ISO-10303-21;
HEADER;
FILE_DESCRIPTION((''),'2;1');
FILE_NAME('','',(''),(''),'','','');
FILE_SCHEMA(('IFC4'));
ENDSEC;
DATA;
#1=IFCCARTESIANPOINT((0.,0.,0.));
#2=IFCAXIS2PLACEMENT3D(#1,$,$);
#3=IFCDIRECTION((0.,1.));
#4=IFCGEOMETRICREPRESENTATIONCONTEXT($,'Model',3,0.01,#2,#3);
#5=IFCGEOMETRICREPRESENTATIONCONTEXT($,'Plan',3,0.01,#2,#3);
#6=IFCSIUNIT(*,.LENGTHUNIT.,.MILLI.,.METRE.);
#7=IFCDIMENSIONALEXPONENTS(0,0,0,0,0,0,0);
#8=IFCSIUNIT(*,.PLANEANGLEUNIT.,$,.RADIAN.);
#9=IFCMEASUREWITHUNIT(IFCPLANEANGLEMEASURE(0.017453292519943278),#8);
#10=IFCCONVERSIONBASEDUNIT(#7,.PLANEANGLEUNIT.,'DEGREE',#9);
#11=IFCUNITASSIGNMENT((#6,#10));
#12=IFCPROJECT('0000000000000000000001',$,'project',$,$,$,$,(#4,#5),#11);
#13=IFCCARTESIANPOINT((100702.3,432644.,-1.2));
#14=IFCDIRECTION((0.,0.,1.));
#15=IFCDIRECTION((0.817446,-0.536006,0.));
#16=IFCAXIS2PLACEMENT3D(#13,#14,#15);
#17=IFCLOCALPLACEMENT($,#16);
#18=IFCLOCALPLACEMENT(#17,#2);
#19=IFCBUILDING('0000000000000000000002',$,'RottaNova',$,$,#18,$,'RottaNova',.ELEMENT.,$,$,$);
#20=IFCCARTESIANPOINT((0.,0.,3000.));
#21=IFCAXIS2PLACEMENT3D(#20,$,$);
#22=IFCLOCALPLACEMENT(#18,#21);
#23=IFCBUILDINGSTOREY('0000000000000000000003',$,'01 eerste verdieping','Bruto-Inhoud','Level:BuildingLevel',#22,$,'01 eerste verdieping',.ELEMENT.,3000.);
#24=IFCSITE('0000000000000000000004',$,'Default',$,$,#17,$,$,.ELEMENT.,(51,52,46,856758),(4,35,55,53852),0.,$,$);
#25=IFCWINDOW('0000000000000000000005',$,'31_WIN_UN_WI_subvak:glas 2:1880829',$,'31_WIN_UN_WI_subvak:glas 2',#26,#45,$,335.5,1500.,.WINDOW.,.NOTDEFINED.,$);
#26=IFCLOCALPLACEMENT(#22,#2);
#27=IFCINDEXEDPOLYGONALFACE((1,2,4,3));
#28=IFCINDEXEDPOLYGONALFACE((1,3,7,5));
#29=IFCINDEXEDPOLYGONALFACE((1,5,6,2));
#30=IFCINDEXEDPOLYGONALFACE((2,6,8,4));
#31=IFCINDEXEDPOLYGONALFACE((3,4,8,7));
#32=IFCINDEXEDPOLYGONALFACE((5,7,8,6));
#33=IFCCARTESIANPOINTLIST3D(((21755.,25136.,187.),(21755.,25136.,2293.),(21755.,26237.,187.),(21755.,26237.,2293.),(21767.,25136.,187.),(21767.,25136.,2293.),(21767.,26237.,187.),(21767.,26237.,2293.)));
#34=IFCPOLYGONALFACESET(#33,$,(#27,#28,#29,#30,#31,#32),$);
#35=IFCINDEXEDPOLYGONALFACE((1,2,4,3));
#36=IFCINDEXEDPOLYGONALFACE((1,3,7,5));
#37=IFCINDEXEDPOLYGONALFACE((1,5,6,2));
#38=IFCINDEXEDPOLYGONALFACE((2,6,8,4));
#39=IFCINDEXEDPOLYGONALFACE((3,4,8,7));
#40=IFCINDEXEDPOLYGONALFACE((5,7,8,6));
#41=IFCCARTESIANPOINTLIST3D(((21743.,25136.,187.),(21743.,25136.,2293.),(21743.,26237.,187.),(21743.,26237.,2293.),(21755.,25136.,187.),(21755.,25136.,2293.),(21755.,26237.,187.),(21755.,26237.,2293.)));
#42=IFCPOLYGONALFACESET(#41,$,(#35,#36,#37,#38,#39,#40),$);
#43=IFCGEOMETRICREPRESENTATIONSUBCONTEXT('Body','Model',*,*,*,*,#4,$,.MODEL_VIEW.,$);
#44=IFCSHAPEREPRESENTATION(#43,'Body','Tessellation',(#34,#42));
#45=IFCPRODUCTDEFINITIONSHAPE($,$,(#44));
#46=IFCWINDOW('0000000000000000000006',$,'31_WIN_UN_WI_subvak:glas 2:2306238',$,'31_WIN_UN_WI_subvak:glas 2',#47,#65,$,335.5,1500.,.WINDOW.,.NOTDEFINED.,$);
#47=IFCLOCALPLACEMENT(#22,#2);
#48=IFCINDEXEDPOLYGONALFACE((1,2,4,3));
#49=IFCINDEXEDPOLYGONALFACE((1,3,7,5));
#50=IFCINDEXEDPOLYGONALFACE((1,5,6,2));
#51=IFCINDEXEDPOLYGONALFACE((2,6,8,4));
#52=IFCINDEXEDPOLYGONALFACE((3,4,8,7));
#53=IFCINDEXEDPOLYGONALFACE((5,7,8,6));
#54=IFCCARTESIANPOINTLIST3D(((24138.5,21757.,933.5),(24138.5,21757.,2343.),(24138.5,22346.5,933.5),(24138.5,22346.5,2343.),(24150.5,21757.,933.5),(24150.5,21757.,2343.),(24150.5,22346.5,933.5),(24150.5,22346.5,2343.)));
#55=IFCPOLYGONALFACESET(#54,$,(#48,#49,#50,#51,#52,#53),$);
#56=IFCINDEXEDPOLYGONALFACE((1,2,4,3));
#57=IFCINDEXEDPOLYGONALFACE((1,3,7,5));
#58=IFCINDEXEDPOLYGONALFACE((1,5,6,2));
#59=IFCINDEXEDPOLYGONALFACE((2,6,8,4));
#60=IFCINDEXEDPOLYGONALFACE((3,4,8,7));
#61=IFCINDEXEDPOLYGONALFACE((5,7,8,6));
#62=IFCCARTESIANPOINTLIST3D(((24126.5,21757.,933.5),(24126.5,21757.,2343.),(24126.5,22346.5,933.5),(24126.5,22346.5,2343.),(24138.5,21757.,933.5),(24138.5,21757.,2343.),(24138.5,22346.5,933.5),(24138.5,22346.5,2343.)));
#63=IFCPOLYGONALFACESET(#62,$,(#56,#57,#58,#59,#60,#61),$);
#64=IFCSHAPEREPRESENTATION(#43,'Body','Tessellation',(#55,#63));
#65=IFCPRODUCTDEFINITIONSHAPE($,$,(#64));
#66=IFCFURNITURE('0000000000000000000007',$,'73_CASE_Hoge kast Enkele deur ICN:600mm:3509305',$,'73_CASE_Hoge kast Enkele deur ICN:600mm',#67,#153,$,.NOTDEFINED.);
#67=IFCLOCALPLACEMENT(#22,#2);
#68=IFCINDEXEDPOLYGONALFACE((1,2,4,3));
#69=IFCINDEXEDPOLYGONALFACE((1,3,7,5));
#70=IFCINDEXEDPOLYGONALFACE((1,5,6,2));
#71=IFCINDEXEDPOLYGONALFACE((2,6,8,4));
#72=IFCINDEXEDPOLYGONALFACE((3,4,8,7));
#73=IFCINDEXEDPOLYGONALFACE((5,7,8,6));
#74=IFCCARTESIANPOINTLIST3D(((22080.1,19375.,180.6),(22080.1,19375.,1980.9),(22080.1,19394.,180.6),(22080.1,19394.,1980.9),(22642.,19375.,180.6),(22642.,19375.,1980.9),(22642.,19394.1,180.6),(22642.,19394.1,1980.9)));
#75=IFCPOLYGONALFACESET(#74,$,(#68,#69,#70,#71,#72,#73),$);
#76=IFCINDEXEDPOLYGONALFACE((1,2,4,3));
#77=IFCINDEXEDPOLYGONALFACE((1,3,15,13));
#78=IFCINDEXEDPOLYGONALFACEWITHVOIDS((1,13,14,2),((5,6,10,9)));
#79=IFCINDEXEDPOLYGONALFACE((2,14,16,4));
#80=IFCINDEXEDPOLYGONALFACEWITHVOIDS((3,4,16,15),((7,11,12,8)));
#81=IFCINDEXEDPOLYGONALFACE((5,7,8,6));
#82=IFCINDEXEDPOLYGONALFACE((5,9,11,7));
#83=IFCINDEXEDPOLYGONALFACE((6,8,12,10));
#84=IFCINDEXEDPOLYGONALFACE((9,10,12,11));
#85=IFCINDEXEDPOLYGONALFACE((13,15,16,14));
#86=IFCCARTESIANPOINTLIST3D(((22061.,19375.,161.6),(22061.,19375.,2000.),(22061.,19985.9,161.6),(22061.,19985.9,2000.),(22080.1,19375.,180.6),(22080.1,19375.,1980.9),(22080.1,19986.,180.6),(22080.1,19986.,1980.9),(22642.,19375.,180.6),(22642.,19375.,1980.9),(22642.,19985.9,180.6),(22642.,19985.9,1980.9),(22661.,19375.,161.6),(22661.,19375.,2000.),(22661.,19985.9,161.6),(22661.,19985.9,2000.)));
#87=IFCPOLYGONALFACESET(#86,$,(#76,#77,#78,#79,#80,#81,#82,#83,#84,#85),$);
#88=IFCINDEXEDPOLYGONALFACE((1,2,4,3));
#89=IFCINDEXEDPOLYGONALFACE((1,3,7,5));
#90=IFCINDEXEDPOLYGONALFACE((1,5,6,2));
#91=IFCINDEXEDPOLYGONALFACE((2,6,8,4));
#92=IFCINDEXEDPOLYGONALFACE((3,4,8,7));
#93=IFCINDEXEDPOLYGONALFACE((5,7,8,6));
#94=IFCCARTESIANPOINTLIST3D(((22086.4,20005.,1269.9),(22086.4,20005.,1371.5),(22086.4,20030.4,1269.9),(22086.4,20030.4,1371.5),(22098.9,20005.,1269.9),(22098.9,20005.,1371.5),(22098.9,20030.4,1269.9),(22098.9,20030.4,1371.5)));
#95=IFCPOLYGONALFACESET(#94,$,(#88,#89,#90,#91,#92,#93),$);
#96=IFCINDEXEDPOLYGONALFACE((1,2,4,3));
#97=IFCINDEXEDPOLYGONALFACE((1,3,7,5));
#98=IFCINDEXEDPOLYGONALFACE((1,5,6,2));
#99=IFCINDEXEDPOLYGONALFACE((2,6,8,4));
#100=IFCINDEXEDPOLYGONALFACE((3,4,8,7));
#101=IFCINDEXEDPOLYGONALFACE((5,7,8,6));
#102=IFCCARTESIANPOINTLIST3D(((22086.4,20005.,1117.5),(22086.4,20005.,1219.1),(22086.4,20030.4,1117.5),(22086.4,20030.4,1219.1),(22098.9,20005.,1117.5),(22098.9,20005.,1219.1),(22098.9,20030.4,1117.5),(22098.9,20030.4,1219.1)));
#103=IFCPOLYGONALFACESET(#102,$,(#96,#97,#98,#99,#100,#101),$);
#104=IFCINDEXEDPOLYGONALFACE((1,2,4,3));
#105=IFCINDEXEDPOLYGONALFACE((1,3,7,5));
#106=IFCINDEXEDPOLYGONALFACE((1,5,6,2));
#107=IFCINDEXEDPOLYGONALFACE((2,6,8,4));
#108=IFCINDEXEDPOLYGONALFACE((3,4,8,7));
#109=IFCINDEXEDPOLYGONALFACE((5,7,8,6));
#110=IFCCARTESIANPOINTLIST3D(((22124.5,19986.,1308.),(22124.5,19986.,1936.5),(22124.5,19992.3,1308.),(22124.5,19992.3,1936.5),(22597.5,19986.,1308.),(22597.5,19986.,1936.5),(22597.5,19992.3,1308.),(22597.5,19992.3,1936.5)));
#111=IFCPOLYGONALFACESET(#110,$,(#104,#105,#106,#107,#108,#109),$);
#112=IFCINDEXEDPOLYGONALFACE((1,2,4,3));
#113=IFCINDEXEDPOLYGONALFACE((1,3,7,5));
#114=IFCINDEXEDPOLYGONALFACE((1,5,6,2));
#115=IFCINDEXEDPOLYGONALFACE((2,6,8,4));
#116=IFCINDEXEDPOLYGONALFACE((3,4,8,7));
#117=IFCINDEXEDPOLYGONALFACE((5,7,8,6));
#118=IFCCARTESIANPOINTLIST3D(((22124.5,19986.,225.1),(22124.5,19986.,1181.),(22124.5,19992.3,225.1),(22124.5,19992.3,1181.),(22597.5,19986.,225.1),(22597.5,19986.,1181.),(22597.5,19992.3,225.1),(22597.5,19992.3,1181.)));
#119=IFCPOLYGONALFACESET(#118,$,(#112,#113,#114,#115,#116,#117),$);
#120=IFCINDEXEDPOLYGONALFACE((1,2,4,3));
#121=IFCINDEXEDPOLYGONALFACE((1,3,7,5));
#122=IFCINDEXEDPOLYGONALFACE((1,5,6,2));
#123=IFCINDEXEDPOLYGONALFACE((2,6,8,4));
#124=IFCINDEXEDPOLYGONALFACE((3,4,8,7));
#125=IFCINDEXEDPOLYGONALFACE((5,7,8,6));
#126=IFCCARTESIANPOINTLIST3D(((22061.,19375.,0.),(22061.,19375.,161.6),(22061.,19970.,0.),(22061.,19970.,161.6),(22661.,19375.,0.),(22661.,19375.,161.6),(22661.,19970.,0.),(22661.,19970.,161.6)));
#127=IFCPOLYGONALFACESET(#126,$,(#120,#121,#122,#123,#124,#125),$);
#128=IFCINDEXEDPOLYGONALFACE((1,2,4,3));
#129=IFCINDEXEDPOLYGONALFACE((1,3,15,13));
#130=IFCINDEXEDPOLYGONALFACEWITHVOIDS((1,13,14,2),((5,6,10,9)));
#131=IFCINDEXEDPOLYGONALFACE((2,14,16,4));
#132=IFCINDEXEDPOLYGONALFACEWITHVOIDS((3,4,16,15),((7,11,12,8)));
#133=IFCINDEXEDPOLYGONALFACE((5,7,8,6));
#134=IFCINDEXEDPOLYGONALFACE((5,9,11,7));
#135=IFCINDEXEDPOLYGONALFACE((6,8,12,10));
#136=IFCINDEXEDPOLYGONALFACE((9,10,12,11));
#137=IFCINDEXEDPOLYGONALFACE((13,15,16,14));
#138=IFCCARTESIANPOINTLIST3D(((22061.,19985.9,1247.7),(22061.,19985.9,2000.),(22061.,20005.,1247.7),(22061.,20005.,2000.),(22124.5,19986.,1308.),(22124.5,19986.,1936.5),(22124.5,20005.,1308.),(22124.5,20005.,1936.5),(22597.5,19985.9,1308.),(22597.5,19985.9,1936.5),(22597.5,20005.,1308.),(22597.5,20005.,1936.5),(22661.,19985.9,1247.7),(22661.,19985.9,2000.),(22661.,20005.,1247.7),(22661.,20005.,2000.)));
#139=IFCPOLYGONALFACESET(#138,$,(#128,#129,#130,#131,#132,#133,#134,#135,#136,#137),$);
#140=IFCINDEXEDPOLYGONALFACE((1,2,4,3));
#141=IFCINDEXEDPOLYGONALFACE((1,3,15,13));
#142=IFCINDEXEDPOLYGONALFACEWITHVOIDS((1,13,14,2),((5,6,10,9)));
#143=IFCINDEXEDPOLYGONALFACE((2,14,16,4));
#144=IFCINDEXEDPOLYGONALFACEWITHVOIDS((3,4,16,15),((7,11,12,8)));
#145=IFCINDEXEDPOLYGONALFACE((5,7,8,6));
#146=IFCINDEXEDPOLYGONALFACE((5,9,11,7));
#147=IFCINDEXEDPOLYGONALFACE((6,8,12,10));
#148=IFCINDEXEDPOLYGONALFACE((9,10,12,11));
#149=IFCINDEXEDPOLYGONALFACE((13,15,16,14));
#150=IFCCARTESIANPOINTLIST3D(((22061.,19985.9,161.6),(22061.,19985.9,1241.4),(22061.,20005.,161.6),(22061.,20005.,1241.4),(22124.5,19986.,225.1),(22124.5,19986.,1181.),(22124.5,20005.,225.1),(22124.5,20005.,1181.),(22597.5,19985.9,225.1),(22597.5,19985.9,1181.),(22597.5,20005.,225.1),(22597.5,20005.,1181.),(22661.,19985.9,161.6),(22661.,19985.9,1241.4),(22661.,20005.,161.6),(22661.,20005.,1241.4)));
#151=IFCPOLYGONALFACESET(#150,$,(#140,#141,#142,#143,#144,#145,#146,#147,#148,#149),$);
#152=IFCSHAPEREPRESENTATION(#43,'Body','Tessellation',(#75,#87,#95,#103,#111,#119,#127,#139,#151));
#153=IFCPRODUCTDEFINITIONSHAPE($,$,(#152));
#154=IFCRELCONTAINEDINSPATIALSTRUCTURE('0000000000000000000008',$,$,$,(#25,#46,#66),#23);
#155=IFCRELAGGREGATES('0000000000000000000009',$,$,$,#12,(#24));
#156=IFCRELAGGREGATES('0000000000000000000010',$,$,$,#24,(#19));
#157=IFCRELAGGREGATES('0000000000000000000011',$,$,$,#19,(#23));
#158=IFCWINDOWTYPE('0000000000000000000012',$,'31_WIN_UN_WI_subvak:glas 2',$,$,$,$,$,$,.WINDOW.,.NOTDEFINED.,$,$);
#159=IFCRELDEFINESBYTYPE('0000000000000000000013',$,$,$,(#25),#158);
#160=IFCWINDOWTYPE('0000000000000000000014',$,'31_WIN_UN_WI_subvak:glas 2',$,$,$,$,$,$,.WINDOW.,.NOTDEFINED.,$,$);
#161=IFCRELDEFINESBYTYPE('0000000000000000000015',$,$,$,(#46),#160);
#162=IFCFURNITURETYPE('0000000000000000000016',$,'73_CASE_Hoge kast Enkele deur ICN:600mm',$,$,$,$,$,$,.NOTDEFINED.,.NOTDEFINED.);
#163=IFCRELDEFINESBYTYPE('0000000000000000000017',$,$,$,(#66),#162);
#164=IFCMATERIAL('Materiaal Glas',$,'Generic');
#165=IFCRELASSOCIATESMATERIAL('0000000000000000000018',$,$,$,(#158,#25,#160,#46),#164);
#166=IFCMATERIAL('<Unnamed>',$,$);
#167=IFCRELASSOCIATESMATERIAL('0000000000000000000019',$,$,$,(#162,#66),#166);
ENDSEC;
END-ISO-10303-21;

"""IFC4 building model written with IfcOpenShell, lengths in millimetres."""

from ifc_helpers import new_model, entity, si_unit, converted_unit, direction, frame, origin, place, context, subcontext, project, spatial, indexed_curve, outline, extrude, source, transform, mapped, material, type_object, type_shapes, element, save


model = new_model("IFC4")

# Units and contexts
model_context = context("Model", 3, precision=0.01, world=origin(), true_north=direction((0.0, 1.0)))
plan_context = context("Plan", 3, precision=0.01, world=origin(), true_north=direction((0.0, 1.0)))
body_context = subcontext(model_context, "Body", "Model", "MODEL_VIEW")
ifc_project = project(units=[si_unit("LENGTHUNIT", "METRE", prefix="MILLI"), converted_unit("PLANEANGLEUNIT", "DEGREE", entity("IfcPlaneAngleMeasure", 0.017453292519943278), si_unit("PLANEANGLEUNIT", "RADIAN"), dimensions=[0, 0, 0, 0, 0, 0, 0])], contexts=[model_context, plan_context])

# Site, building, storey
site_placement = place(None, frame((100702.3, 432644.0, -1.2), z_axis=(0.0, 0.0, 1.0), x_axis=(0.817446, -0.536006, 0.0)))
site = spatial("IfcSite", under=ifc_project, at=site_placement, Name="Default", CompositionType="ELEMENT", RefLatitude=(51, 52, 46, 856758), RefLongitude=(4, 35, 55, 53852), RefElevation=0.0)
building_placement = place(site_placement, origin())
building = spatial("IfcBuilding", under=site, at=building_placement, Name="RottaNova", LongName="RottaNova", CompositionType="ELEMENT")
storey_placement = place(building_placement, frame((0.0, 0.0, 3000.0)))
storey = spatial("IfcBuildingStorey", under=building, at=storey_placement, Name="01 eerste verdieping", Description="Bruto-Inhoud", ObjectType="Level:BuildingLevel", LongName="01 eerste verdieping", CompositionType="ELEMENT", Elevation=3000.0)

# Shared definitions
ifc_material_1 = material(Name="Materiaal Glas", Category="Generic")

# Windows
window_type_1 = type_object("IfcWindowType", Name="31_WIN_UN_WI_subvak:glas 2", PartitioningType="NOTDEFINED", PredefinedType="WINDOW", material=ifc_material_1)
shared_shape_1 = source(origin(), body_context, "Body", "SweptSolid", [
    extrude(outline(indexed_curve([(-6.0, -550.5), (6.0, -550.5), (6.0, 550.5), (-6.0, 550.5), (-6.0, -550.5)], self_intersect=False)), frame((0.0, 6.0, 0.0), z_axis=(0.0, 0.0, 1.0), x_axis=(0.0, -1.0, 0.0)), (0.0, 0.0, 1.0), 2106.0),
    extrude(outline(indexed_curve([(-6.0, -550.5), (6.0, -550.5), (6.0, 550.5), (-6.0, 550.5), (-6.0, -550.5)], self_intersect=False)), frame((0.0, -6.0, 0.0), z_axis=(0.0, 0.0, 1.0), x_axis=(0.0, -1.0, 0.0)), (0.0, 0.0, 1.0), 2106.0),
])
type_shapes(window_type_1, [shared_shape_1])
window_1_placement = place(storey_placement, frame((21755.0, 25686.5, 187.0), z_axis=(0.0, 0.0, 1.0), x_axis=(0.0, -1.0, 0.0)))
element("IfcWindow", 1, at=window_1_placement, inside=storey, type_object=window_type_1, material=ifc_material_1, Name="31_WIN_UN_WI_subvak:glas 2:1880829", ObjectType="31_WIN_UN_WI_subvak:glas 2", OverallHeight=335.5, OverallWidth=1500.0, PartitioningType="NOTDEFINED", PredefinedType="WINDOW", context=body_context, shape_type="MappedRepresentation", body=[
    mapped(shared_shape_1, transform((0.0, 0.0, 0.0), scale=1.0)),
])
window_type_2 = type_object("IfcWindowType", Name="31_WIN_UN_WI_subvak:glas 2", PartitioningType="NOTDEFINED", PredefinedType="WINDOW", material=ifc_material_1)
shared_shape_2 = source(origin(), body_context, "Body", "SweptSolid", [
    extrude(outline(indexed_curve([(-294.7, -6.0), (294.7, -6.0), (294.7, 6.0), (-294.7, 6.0), (-294.7, -6.0)], self_intersect=False)), frame((0.0, -6.0, 0.0)), (0.0, 0.0, 1.0), 1409.5),
    extrude(outline(indexed_curve([(-294.8, -6.0), (294.8, -6.0), (294.8, 6.0), (-294.8, 6.0), (-294.8, -6.0)], self_intersect=False)), frame((0.0, 6.0, 0.0)), (0.0, 0.0, 1.0), 1409.5),
])
type_shapes(window_type_2, [shared_shape_2])
window_2_placement = place(storey_placement, frame((24138.5, 22051.7, 933.5), z_axis=(0.0, 0.0, 1.0), x_axis=(0.0, 1.0, 0.0)))
element("IfcWindow", 2, at=window_2_placement, inside=storey, type_object=window_type_2, material=ifc_material_1, Name="31_WIN_UN_WI_subvak:glas 2:2306238", ObjectType="31_WIN_UN_WI_subvak:glas 2", OverallHeight=335.5, OverallWidth=1500.0, PartitioningType="NOTDEFINED", PredefinedType="WINDOW", context=body_context, shape_type="MappedRepresentation", body=[
    mapped(shared_shape_2, transform((0.0, 0.0, 0.0), scale=1.0)),
])

# Furniture
ifc_material_2 = material(Name="<Unnamed>")
furniture_type = type_object("IfcFurnitureType", Name="73_CASE_Hoge kast Enkele deur ICN:600mm", AssemblyPlace="NOTDEFINED", PredefinedType="NOTDEFINED", material=ifc_material_2)
shared_shape_3 = source(origin(), body_context, "Body", "SweptSolid", [
    extrude(outline(indexed_curve([(-9.5, -280.9), (9.5, -280.9), (9.5, 280.9), (-9.5, 280.9), (-9.5, -280.9)], self_intersect=False)), frame((18.7, -9.5, 180.6), z_axis=(0.0, 0.0, 1.0), x_axis=(0.0, 1.0, 0.0)), (0.0, 0.0, 1.0), 1800.3),
    extrude(outline(indexed_curve([(-300.0, -919.2), (300.0, -919.2), (300.0, 919.2), (-300.0, 919.2), (-300.0, -919.2)], self_intersect=False), holes=[indexed_curve([(-280.9, 900.2), (281.0, 900.2), (281.0, -900.2), (-280.9, -900.2), (-280.9, 900.2)], self_intersect=False)]), frame((18.7, -610.9, 1080.8), z_axis=(0.0, 1.0, 0.0), x_axis=(-1.0, 0.0, 0.0)), (0.0, 0.0, 1.0), 610.9),
    extrude(outline(indexed_curve([(-12.7, -6.3), (12.7, -6.3), (12.7, 6.3), (-12.7, 6.3), (-12.7, -6.3)], self_intersect=False)), frame((287.1, -642.7, 1269.9), z_axis=(0.0, 0.0, 1.0), x_axis=(0.0, 1.0, 0.0)), (0.0, 0.0, 1.0), 101.6),
    extrude(outline(indexed_curve([(-12.7, -6.3), (12.7, -6.3), (12.7, 6.3), (-12.7, 6.3), (-12.7, -6.3)], self_intersect=False)), frame((287.1, -642.7, 1117.5), z_axis=(0.0, 0.0, 1.0), x_axis=(0.0, 1.0, 0.0)), (0.0, 0.0, 1.0), 101.6),
    extrude(outline(indexed_curve([(-3.2, -236.5), (3.2, -236.5), (3.2, 236.5), (-3.2, 236.5), (-3.2, -236.5)], self_intersect=False)), frame((18.7, -614.1, 1308.0), z_axis=(0.0, 0.0, 1.0), x_axis=(0.0, 1.0, 0.0)), (0.0, 0.0, 1.0), 628.5),
    extrude(outline(indexed_curve([(-3.2, -236.5), (3.2, -236.5), (3.2, 236.5), (-3.2, 236.5), (-3.2, -236.5)], self_intersect=False)), frame((18.7, -614.1, 225.1), z_axis=(0.0, 0.0, 1.0), x_axis=(0.0, 1.0, 0.0)), (0.0, 0.0, 1.0), 956.0),
    extrude(outline(indexed_curve([(-300.0, -297.5), (300.0, -297.5), (300.0, 297.5), (-300.0, 297.5), (-300.0, -297.5)], self_intersect=False)), frame((18.7, -297.5, 0.0), z_axis=(0.0, 0.0, 1.0), x_axis=(-1.0, 0.0, 0.0)), (0.0, 0.0, 1.0), 161.6),
    extrude(outline(indexed_curve([(-376.1, -300.0), (376.1, -300.0), (376.1, 300.0), (-376.1, 300.0), (-376.1, -300.0)], self_intersect=False), holes=[indexed_curve([(-312.6, -236.5), (-312.6, 236.5), (315.8, 236.5), (315.8, -236.5), (-312.6, -236.5)], self_intersect=False)]), frame((18.7, -630.0, 1623.9), z_axis=(0.0, 1.0, 0.0), x_axis=(0.0, 0.0, -1.0)), (0.0, 0.0, 1.0), 19.1),
    extrude(outline(indexed_curve([(-300.0, -539.9), (300.0, -539.9), (300.0, 539.9), (-300.0, 539.9), (-300.0, -539.9)], self_intersect=False), holes=[indexed_curve([(-236.5, 479.6), (236.5, 479.6), (236.5, -476.4), (-236.5, -476.4), (-236.5, 479.6)], self_intersect=False)]), frame((18.7, -630.0, 701.5), z_axis=(0.0, 1.0, 0.0), x_axis=(-1.0, 0.0, 0.0)), (0.0, 0.0, 1.0), 19.1),
])
type_shapes(furniture_type, [shared_shape_3])
for number, where, z_axis, x_axis, name in (
    (3, (22379.7, 19375.0, 0.0), (0.0, 0.0, 1.0), (-1.0, 0.0, 0.0), "73_CASE_Hoge kast Enkele deur ICN:600mm:3509305"),
):
    element("IfcFurniture", number, at=place(storey_placement, frame(where, z_axis=z_axis, x_axis=x_axis)), inside=storey, type_object=furniture_type, material=ifc_material_2, Name=name, ObjectType="73_CASE_Hoge kast Enkele deur ICN:600mm", PredefinedType="NOTDEFINED", context=body_context, shape_type="MappedRepresentation", body=[
        mapped(shared_shape_3, transform((0.0, 0.0, 0.0), scale=1.0)),
    ])

save(model, "model.ifc")
